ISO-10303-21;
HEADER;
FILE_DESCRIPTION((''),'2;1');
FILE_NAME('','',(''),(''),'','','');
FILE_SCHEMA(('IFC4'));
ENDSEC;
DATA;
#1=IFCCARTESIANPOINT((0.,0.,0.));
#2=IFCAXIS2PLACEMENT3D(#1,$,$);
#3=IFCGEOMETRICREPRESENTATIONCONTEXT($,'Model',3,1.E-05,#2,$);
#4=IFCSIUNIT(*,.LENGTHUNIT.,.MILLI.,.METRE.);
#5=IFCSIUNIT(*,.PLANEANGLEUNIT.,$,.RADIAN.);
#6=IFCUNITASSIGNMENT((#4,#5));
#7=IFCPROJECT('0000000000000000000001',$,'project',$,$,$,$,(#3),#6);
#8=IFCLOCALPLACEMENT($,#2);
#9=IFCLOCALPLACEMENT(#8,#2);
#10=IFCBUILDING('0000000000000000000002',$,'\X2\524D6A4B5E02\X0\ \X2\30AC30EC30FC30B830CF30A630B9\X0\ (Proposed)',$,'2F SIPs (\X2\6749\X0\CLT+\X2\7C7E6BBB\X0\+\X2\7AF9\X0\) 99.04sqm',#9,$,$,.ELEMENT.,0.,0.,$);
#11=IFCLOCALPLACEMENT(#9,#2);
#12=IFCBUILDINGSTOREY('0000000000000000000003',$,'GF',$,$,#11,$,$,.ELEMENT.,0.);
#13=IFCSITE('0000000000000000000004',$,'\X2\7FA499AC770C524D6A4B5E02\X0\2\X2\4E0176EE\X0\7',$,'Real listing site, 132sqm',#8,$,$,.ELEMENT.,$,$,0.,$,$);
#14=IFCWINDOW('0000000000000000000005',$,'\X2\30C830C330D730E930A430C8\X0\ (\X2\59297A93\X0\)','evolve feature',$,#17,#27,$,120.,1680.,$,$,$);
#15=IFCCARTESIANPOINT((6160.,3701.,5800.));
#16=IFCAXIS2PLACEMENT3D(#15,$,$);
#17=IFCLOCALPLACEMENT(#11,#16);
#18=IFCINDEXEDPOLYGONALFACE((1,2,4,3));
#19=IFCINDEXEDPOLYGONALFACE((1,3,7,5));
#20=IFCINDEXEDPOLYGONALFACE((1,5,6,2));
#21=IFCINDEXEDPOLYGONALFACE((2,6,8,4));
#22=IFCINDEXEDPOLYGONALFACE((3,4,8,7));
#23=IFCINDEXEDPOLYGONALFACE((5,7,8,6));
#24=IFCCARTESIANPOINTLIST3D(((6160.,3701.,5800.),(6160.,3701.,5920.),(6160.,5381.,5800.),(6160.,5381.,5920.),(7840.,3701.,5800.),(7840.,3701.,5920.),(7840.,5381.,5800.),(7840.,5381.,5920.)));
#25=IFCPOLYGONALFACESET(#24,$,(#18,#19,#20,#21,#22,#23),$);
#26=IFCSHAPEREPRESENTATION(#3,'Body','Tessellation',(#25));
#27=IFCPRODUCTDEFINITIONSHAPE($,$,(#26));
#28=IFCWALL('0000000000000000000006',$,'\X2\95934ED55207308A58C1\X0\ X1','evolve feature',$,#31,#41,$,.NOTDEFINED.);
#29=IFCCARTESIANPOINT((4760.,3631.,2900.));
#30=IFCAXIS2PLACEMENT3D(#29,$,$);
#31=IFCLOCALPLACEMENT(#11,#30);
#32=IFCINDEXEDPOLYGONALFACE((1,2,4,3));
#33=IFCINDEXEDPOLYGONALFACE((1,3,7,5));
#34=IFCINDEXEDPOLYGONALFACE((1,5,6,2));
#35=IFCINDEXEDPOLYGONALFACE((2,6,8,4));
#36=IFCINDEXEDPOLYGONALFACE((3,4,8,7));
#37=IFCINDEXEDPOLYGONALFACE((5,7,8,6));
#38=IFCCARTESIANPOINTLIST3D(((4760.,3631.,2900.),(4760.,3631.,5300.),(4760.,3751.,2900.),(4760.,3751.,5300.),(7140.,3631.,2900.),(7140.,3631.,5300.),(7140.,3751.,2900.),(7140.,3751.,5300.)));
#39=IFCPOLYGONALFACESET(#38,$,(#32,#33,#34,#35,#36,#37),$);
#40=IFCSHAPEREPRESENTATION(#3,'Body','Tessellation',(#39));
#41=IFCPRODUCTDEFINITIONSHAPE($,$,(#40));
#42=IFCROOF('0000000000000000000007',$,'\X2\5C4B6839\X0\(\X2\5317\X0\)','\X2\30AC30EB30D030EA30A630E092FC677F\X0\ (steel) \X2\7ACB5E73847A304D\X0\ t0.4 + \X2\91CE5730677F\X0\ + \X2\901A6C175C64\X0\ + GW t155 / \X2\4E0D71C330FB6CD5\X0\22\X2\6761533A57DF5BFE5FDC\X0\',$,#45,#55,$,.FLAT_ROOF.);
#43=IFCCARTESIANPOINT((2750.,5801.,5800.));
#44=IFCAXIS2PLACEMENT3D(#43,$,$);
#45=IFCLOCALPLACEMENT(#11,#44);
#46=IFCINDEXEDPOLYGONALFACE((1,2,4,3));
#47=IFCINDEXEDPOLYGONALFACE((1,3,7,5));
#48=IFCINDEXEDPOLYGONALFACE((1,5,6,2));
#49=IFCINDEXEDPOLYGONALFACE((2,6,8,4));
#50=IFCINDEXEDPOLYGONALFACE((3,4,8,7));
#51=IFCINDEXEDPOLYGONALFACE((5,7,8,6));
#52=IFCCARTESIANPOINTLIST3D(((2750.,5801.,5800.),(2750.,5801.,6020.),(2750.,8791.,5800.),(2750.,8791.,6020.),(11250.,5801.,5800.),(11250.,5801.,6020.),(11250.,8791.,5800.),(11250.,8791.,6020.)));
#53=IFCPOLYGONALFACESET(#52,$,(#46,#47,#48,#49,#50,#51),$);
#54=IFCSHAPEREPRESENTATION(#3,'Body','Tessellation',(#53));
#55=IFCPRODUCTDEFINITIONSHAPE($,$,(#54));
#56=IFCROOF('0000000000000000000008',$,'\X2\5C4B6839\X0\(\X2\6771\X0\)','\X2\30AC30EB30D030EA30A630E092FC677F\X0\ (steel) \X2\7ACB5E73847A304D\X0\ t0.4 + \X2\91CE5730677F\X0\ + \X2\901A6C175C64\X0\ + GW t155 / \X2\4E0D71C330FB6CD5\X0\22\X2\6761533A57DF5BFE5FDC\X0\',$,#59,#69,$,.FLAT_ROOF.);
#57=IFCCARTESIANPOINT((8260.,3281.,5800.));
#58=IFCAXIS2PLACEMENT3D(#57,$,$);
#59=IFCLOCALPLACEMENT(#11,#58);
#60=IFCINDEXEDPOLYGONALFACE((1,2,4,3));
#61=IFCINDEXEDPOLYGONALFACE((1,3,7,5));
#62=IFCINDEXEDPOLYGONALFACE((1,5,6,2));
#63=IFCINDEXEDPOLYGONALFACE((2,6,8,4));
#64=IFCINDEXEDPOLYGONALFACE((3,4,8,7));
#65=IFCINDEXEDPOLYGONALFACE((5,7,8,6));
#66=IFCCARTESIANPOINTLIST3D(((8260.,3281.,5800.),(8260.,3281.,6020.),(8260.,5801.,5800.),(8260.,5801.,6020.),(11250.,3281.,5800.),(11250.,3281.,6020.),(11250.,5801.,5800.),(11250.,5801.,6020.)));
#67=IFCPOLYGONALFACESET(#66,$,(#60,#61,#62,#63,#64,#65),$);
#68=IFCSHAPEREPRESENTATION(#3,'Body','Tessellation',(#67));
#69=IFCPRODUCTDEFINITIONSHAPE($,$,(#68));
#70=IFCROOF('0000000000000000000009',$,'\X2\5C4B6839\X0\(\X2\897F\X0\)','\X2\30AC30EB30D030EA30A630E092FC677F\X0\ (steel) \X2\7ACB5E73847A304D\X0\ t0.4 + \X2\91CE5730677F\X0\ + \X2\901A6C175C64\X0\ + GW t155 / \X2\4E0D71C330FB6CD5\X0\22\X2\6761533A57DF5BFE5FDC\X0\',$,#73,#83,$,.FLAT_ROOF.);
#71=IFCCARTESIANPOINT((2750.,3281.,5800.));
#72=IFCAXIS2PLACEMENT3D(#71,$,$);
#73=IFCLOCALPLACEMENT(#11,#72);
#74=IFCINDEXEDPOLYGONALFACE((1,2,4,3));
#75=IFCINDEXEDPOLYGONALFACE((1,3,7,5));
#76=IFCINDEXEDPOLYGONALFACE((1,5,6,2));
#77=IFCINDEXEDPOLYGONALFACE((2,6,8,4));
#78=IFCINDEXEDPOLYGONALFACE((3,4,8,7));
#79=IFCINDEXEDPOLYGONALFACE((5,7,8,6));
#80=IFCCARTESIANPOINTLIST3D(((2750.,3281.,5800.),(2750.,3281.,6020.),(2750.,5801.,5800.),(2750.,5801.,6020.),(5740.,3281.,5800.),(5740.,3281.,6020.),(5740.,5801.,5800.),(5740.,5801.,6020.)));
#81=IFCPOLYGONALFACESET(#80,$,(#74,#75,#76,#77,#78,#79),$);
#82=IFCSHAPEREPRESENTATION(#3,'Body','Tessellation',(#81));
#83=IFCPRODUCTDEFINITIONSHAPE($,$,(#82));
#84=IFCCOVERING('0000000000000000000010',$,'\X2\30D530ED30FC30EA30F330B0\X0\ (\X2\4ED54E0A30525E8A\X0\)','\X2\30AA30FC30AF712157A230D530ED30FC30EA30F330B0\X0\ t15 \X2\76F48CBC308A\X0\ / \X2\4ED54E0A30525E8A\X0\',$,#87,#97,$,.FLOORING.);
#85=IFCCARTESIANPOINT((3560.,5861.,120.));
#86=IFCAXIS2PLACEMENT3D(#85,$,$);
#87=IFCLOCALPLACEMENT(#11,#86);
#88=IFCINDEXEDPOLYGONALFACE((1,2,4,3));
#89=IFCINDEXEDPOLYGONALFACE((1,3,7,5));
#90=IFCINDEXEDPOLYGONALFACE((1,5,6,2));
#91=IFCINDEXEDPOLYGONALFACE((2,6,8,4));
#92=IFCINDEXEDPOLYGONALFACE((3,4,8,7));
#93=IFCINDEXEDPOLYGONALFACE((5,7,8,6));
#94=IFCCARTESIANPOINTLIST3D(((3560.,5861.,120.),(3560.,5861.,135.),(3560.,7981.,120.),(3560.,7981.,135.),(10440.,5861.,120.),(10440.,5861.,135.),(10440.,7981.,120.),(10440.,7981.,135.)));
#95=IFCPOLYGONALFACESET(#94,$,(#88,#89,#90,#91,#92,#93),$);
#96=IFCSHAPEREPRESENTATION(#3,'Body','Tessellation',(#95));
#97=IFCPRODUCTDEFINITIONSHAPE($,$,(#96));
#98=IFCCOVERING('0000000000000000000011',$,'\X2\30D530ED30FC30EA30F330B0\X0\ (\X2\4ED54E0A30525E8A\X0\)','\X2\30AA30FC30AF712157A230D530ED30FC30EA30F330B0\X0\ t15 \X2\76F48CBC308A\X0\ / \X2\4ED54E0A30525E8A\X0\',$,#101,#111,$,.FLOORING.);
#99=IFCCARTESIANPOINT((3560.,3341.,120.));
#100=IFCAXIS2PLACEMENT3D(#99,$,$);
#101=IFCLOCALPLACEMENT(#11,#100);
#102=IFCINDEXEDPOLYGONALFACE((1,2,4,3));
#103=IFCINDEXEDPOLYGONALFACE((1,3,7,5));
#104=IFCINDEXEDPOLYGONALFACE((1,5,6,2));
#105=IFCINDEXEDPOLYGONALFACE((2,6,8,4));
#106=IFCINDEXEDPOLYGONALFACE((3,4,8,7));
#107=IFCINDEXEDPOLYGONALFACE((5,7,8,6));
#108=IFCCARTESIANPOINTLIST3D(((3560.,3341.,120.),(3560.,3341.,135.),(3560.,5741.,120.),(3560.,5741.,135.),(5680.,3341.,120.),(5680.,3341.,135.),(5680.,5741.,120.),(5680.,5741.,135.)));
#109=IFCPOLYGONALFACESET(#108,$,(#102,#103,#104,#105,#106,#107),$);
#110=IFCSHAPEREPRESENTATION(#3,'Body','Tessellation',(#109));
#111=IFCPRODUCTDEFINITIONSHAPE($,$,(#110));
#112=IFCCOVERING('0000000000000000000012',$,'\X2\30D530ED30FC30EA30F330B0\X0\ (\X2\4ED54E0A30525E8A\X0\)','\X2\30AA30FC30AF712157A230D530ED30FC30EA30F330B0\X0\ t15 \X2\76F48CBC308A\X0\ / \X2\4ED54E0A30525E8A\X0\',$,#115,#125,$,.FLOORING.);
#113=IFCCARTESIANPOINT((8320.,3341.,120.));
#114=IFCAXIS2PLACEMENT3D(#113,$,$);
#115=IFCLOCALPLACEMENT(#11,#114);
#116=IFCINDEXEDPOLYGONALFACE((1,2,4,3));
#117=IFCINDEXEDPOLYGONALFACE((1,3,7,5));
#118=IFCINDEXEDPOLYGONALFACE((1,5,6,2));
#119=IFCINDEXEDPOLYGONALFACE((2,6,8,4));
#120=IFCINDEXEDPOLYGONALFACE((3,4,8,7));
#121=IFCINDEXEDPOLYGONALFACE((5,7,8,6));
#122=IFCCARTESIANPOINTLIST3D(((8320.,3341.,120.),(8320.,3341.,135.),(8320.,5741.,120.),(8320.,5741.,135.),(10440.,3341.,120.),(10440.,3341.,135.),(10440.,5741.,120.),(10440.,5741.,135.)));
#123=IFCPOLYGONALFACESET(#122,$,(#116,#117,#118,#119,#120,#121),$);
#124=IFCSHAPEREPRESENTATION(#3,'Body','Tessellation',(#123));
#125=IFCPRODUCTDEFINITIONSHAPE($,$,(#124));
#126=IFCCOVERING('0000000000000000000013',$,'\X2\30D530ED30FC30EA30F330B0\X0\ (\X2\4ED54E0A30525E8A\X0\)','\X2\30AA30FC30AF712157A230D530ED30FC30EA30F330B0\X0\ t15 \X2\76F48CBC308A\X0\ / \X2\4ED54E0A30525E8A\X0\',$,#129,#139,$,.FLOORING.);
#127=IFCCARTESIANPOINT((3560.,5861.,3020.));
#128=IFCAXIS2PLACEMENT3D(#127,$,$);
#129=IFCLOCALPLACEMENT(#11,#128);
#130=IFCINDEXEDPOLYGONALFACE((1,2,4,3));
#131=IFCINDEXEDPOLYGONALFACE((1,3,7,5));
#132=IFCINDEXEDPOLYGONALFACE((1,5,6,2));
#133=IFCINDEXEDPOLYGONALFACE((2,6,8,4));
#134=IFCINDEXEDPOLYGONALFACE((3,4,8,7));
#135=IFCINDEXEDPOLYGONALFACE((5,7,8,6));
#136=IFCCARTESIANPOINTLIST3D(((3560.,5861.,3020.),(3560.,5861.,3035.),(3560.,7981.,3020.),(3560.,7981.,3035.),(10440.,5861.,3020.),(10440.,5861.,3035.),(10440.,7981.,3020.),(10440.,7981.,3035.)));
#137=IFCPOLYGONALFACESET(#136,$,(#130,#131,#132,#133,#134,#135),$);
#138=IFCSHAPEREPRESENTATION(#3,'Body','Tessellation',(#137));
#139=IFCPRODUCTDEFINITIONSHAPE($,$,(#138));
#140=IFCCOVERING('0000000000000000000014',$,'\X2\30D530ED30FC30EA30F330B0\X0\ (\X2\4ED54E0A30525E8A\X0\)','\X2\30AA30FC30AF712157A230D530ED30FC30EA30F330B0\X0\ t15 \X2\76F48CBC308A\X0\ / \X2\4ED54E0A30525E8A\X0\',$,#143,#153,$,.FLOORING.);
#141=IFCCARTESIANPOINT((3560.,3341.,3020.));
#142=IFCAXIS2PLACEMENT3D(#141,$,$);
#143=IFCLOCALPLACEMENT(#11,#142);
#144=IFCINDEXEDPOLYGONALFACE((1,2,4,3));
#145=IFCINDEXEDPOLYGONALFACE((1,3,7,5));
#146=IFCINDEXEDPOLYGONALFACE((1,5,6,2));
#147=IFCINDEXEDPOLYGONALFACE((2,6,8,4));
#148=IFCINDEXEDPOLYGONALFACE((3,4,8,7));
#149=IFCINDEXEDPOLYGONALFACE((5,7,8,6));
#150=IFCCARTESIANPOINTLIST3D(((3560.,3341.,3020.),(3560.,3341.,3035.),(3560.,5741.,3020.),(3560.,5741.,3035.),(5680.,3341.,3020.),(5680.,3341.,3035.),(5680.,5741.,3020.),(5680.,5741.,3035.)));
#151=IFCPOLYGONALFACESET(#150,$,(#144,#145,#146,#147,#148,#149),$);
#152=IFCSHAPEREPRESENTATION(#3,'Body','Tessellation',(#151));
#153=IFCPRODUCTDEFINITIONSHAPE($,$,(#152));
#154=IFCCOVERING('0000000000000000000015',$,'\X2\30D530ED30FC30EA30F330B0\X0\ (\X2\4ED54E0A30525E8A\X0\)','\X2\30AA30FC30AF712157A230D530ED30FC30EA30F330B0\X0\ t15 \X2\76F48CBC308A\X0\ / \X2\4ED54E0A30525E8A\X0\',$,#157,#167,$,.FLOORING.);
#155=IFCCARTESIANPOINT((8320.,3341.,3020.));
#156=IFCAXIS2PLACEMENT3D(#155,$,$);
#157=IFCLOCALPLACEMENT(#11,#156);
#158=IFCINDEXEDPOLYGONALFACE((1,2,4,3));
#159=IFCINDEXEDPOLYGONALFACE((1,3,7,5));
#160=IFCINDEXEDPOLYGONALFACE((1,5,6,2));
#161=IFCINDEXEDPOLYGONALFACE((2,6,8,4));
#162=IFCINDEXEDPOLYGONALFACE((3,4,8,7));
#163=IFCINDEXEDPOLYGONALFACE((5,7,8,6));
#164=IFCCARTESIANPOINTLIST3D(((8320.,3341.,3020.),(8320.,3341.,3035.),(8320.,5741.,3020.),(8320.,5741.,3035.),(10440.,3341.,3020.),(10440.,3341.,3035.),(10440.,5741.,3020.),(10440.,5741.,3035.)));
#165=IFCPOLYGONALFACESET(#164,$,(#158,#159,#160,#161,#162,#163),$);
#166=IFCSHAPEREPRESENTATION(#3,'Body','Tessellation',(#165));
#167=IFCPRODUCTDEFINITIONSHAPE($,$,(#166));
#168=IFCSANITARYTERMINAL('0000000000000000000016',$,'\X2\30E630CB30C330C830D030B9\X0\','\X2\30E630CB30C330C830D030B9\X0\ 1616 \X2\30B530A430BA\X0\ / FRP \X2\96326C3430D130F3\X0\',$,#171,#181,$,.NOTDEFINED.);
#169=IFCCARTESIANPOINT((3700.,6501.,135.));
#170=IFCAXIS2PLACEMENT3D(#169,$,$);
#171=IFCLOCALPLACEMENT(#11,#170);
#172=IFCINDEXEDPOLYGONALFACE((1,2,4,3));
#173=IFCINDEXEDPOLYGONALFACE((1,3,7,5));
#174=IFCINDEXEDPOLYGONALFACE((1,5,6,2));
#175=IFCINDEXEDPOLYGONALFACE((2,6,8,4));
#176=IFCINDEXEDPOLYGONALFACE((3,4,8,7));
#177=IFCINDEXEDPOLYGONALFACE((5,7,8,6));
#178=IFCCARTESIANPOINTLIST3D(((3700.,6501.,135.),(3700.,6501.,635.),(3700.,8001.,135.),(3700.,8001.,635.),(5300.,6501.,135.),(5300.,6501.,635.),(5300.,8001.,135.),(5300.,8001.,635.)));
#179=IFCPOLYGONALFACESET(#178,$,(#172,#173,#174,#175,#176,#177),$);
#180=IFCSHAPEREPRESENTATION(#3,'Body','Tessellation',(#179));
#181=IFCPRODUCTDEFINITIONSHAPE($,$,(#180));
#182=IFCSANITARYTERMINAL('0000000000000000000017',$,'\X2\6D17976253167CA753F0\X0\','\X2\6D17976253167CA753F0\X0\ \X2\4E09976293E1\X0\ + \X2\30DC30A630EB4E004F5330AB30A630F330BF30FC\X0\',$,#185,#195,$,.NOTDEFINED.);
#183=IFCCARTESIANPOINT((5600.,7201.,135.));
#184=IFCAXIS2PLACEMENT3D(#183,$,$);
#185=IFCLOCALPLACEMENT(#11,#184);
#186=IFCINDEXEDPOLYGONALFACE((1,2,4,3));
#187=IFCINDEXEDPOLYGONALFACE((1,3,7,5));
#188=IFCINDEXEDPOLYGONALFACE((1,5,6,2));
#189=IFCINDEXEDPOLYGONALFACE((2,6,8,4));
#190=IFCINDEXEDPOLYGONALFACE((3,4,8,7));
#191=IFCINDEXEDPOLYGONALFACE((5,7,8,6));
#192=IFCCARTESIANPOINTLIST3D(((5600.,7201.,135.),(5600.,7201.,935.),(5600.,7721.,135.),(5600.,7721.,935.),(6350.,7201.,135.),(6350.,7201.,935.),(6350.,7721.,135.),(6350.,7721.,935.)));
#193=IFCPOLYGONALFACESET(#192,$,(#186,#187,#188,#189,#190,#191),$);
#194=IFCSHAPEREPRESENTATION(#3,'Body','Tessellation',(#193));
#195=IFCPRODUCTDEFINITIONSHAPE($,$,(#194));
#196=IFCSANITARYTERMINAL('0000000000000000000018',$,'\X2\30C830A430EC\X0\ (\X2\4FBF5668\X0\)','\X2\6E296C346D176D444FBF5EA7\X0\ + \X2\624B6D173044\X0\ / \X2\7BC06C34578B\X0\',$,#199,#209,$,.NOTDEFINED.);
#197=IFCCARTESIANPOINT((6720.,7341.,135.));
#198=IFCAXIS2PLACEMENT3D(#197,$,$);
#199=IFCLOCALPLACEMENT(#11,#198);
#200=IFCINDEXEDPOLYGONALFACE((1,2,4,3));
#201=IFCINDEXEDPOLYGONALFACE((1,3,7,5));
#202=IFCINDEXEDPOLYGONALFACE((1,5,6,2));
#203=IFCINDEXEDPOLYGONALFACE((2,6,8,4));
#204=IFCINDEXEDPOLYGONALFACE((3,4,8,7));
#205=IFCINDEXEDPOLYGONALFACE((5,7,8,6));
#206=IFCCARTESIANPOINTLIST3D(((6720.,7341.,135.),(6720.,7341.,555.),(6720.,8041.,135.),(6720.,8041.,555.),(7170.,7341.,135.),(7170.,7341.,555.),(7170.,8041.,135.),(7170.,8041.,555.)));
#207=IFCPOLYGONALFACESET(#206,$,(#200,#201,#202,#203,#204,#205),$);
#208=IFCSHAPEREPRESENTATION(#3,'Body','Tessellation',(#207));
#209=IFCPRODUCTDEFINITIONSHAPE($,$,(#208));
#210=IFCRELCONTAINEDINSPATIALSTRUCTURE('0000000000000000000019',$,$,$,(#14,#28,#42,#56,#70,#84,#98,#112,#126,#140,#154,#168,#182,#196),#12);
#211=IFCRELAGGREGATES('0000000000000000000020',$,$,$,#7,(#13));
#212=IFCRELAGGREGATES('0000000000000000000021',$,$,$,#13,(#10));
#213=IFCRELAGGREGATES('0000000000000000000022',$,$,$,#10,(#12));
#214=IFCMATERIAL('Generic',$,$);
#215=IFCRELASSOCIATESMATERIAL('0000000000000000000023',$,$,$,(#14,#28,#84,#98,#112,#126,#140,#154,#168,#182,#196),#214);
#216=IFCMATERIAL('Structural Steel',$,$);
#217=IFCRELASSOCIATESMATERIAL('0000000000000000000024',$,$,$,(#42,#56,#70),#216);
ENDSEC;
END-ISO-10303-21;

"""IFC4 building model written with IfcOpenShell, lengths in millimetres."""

from ifc_helpers import new_model, si_unit, frame, frame_2d, origin, place, context, project, spatial, rectangle, extrude, material, element, save


model = new_model("IFC4")

# Units and contexts
model_context = context("Model", 3, precision=1e-05, world=origin())
ifc_project = project(units=[si_unit("LENGTHUNIT", "METRE", prefix="MILLI"), si_unit("PLANEANGLEUNIT", "RADIAN")], contexts=[model_context])

# Site, building, storey
site_placement = place(None, origin())
site = spatial("IfcSite", under=ifc_project, at=site_placement, Name="群馬県前橋市2丁目7", ObjectType="Real listing site, 132sqm", CompositionType="ELEMENT", RefElevation=0.0)
building_placement = place(site_placement, origin())
building = spatial("IfcBuilding", under=site, at=building_placement, Name="前橋市 ガレージハウス (Proposed)", ObjectType="2F SIPs (杉CLT+籾殻+竹) 99.04sqm", CompositionType="ELEMENT", ElevationOfRefHeight=0.0, ElevationOfTerrain=0.0)
storey_placement = place(building_placement, origin())
storey = spatial("IfcBuildingStorey", under=building, at=storey_placement, Name="GF", CompositionType="ELEMENT", Elevation=0.0)

# Window
ifc_material_1 = material(Name="Generic")
window_1_placement = place(storey_placement, frame((6160.0, 3701.0, 5800.0)))
element("IfcWindow", 1, at=window_1_placement, inside=storey, material=ifc_material_1, Name="トップライト (天窓)", Description="evolve feature", OverallHeight=120.0, OverallWidth=1680.0, context=model_context, shape_type="SweptSolid", body=[
    extrude(rectangle(XDim=1680.0, YDim=1680.0, at=frame_2d((840.0, 840.0))), frame((6160.0, 3701.0, 5800.0)), (0.0, 0.0, 1.0), 120.0),
])

# Wall
wall_1_placement = place(storey_placement, frame((4760.0, 3631.0, 2900.0)))
element("IfcWall", 2, at=wall_1_placement, inside=storey, material=ifc_material_1, Name="間仕切り壁 X1", Description="evolve feature", PredefinedType="NOTDEFINED", context=model_context, shape_type="SweptSolid", body=[
    extrude(rectangle(XDim=2380.0, YDim=120.0, at=frame_2d((1190.0, 60.0))), frame((4760.0, 3631.0, 2900.0)), (0.0, 0.0, 1.0), 2400.0),
])

# Roofs
ifc_material_2 = material(Name="Structural Steel")
roof_1_placement = place(storey_placement, frame((2750.0, 5801.0, 5800.0)))
element("IfcRoof", 3, at=roof_1_placement, inside=storey, material=ifc_material_2, Name="屋根(北)", Description="ガルバリウム鋼板 (steel) 立平葺き t0.4 + 野地板 + 通気層 + GW t155 / 不燃・法22条区域対応", PredefinedType="FLAT_ROOF", context=model_context, shape_type="SweptSolid", body=[
    extrude(rectangle(XDim=8500.0, YDim=2990.0, at=frame_2d((4250.0, 1495.0))), frame((2750.0, 5801.0, 5800.0)), (0.0, 0.0, 1.0), 220.0),
])
roof_2_placement = place(storey_placement, frame((8260.0, 3281.0, 5800.0)))
element("IfcRoof", 4, at=roof_2_placement, inside=storey, material=ifc_material_2, Name="屋根(東)", Description="ガルバリウム鋼板 (steel) 立平葺き t0.4 + 野地板 + 通気層 + GW t155 / 不燃・法22条区域対応", PredefinedType="FLAT_ROOF", context=model_context, shape_type="SweptSolid", body=[
    extrude(rectangle(XDim=2990.0, YDim=2520.0, at=frame_2d((1495.0, 1260.0))), frame((8260.0, 3281.0, 5800.0)), (0.0, 0.0, 1.0), 220.0),
])
roof_3_placement = place(storey_placement, frame((2750.0, 3281.0, 5800.0)))
element("IfcRoof", 5, at=roof_3_placement, inside=storey, material=ifc_material_2, Name="屋根(西)", Description="ガルバリウム鋼板 (steel) 立平葺き t0.4 + 野地板 + 通気層 + GW t155 / 不燃・法22条区域対応", PredefinedType="FLAT_ROOF", context=model_context, shape_type="SweptSolid", body=[
    extrude(rectangle(XDim=2990.0, YDim=2520.0, at=frame_2d((1495.0, 1260.0))), frame((2750.0, 3281.0, 5800.0)), (0.0, 0.0, 1.0), 220.0),
])

# Coverings
covering_1_placement = place(storey_placement, frame((3560.0, 5861.0, 120.0)))
element("IfcCovering", 6, at=covering_1_placement, inside=storey, material=ifc_material_1, Name="フローリング (仕上げ床)", Description="オーク無垢フローリング t15 直貼り / 仕上げ床", PredefinedType="FLOORING", context=model_context, shape_type="SweptSolid", body=[
    extrude(rectangle(XDim=6880.0, YDim=2120.0, at=frame_2d((3440.0, 1060.0))), frame((3560.0, 5861.0, 120.0)), (0.0, 0.0, 1.0), 15.0),
])
covering_2_placement = place(storey_placement, frame((3560.0, 3341.0, 120.0)))
element("IfcCovering", 7, at=covering_2_placement, inside=storey, material=ifc_material_1, Name="フローリング (仕上げ床)", Description="オーク無垢フローリング t15 直貼り / 仕上げ床", PredefinedType="FLOORING", context=model_context, shape_type="SweptSolid", body=[
    extrude(rectangle(XDim=2120.0, YDim=2400.0, at=frame_2d((1060.0, 1200.0))), frame((3560.0, 3341.0, 120.0)), (0.0, 0.0, 1.0), 15.0),
])
covering_3_placement = place(storey_placement, frame((8320.0, 3341.0, 120.0)))
element("IfcCovering", 8, at=covering_3_placement, inside=storey, material=ifc_material_1, Name="フローリング (仕上げ床)", Description="オーク無垢フローリング t15 直貼り / 仕上げ床", PredefinedType="FLOORING", context=model_context, shape_type="SweptSolid", body=[
    extrude(rectangle(XDim=2120.0, YDim=2400.0, at=frame_2d((1060.0, 1200.0))), frame((8320.0, 3341.0, 120.0)), (0.0, 0.0, 1.0), 15.0),
])
covering_4_placement = place(storey_placement, frame((3560.0, 5861.0, 3020.0)))
element("IfcCovering", 9, at=covering_4_placement, inside=storey, material=ifc_material_1, Name="フローリング (仕上げ床)", Description="オーク無垢フローリング t15 直貼り / 仕上げ床", PredefinedType="FLOORING", context=model_context, shape_type="SweptSolid", body=[
    extrude(rectangle(XDim=6880.0, YDim=2120.0, at=frame_2d((3440.0, 1060.0))), frame((3560.0, 5861.0, 3020.0)), (0.0, 0.0, 1.0), 15.0),
])
covering_5_placement = place(storey_placement, frame((3560.0, 3341.0, 3020.0)))
element("IfcCovering", 10, at=covering_5_placement, inside=storey, material=ifc_material_1, Name="フローリング (仕上げ床)", Description="オーク無垢フローリング t15 直貼り / 仕上げ床", PredefinedType="FLOORING", context=model_context, shape_type="SweptSolid", body=[
    extrude(rectangle(XDim=2120.0, YDim=2400.0, at=frame_2d((1060.0, 1200.0))), frame((3560.0, 3341.0, 3020.0)), (0.0, 0.0, 1.0), 15.0),
])
covering_6_placement = place(storey_placement, frame((8320.0, 3341.0, 3020.0)))
element("IfcCovering", 11, at=covering_6_placement, inside=storey, material=ifc_material_1, Name="フローリング (仕上げ床)", Description="オーク無垢フローリング t15 直貼り / 仕上げ床", PredefinedType="FLOORING", context=model_context, shape_type="SweptSolid", body=[
    extrude(rectangle(XDim=2120.0, YDim=2400.0, at=frame_2d((1060.0, 1200.0))), frame((8320.0, 3341.0, 3020.0)), (0.0, 0.0, 1.0), 15.0),
])

# Sanitary terminals
sanitary_terminal_1_placement = place(storey_placement, frame((3700.0, 6501.0, 135.0)))
element("IfcSanitaryTerminal", 12, at=sanitary_terminal_1_placement, inside=storey, material=ifc_material_1, Name="ユニットバス", Description="ユニットバス 1616 サイズ / FRP 防水パン", PredefinedType="NOTDEFINED", context=model_context, shape_type="SweptSolid", body=[
    extrude(rectangle(XDim=1600.0, YDim=1500.0, at=frame_2d((800.0, 750.0))), frame((3700.0, 6501.0, 135.0)), (0.0, 0.0, 1.0), 500.0),
])
sanitary_terminal_2_placement = place(storey_placement, frame((5600.0, 7201.0, 135.0)))
element("IfcSanitaryTerminal", 13, at=sanitary_terminal_2_placement, inside=storey, material=ifc_material_1, Name="洗面化粧台", Description="洗面化粧台 三面鏡 + ボウル一体カウンター", PredefinedType="NOTDEFINED", context=model_context, shape_type="SweptSolid", body=[
    extrude(rectangle(XDim=750.0, YDim=520.0, at=frame_2d((375.0, 260.0))), frame((5600.0, 7201.0, 135.0)), (0.0, 0.0, 1.0), 800.0),
])
sanitary_terminal_3_placement = place(storey_placement, frame((6720.0, 7341.0, 135.0)))
element("IfcSanitaryTerminal", 14, at=sanitary_terminal_3_placement, inside=storey, material=ifc_material_1, Name="トイレ (便器)", Description="温水洗浄便座 + 手洗い / 節水型", PredefinedType="NOTDEFINED", context=model_context, shape_type="SweptSolid", body=[
    extrude(rectangle(XDim=450.0, YDim=700.0, at=frame_2d((225.0, 350.0))), frame((6720.0, 7341.0, 135.0)), (0.0, 0.0, 1.0), 420.0),
])

save(model, "model.ifc")
